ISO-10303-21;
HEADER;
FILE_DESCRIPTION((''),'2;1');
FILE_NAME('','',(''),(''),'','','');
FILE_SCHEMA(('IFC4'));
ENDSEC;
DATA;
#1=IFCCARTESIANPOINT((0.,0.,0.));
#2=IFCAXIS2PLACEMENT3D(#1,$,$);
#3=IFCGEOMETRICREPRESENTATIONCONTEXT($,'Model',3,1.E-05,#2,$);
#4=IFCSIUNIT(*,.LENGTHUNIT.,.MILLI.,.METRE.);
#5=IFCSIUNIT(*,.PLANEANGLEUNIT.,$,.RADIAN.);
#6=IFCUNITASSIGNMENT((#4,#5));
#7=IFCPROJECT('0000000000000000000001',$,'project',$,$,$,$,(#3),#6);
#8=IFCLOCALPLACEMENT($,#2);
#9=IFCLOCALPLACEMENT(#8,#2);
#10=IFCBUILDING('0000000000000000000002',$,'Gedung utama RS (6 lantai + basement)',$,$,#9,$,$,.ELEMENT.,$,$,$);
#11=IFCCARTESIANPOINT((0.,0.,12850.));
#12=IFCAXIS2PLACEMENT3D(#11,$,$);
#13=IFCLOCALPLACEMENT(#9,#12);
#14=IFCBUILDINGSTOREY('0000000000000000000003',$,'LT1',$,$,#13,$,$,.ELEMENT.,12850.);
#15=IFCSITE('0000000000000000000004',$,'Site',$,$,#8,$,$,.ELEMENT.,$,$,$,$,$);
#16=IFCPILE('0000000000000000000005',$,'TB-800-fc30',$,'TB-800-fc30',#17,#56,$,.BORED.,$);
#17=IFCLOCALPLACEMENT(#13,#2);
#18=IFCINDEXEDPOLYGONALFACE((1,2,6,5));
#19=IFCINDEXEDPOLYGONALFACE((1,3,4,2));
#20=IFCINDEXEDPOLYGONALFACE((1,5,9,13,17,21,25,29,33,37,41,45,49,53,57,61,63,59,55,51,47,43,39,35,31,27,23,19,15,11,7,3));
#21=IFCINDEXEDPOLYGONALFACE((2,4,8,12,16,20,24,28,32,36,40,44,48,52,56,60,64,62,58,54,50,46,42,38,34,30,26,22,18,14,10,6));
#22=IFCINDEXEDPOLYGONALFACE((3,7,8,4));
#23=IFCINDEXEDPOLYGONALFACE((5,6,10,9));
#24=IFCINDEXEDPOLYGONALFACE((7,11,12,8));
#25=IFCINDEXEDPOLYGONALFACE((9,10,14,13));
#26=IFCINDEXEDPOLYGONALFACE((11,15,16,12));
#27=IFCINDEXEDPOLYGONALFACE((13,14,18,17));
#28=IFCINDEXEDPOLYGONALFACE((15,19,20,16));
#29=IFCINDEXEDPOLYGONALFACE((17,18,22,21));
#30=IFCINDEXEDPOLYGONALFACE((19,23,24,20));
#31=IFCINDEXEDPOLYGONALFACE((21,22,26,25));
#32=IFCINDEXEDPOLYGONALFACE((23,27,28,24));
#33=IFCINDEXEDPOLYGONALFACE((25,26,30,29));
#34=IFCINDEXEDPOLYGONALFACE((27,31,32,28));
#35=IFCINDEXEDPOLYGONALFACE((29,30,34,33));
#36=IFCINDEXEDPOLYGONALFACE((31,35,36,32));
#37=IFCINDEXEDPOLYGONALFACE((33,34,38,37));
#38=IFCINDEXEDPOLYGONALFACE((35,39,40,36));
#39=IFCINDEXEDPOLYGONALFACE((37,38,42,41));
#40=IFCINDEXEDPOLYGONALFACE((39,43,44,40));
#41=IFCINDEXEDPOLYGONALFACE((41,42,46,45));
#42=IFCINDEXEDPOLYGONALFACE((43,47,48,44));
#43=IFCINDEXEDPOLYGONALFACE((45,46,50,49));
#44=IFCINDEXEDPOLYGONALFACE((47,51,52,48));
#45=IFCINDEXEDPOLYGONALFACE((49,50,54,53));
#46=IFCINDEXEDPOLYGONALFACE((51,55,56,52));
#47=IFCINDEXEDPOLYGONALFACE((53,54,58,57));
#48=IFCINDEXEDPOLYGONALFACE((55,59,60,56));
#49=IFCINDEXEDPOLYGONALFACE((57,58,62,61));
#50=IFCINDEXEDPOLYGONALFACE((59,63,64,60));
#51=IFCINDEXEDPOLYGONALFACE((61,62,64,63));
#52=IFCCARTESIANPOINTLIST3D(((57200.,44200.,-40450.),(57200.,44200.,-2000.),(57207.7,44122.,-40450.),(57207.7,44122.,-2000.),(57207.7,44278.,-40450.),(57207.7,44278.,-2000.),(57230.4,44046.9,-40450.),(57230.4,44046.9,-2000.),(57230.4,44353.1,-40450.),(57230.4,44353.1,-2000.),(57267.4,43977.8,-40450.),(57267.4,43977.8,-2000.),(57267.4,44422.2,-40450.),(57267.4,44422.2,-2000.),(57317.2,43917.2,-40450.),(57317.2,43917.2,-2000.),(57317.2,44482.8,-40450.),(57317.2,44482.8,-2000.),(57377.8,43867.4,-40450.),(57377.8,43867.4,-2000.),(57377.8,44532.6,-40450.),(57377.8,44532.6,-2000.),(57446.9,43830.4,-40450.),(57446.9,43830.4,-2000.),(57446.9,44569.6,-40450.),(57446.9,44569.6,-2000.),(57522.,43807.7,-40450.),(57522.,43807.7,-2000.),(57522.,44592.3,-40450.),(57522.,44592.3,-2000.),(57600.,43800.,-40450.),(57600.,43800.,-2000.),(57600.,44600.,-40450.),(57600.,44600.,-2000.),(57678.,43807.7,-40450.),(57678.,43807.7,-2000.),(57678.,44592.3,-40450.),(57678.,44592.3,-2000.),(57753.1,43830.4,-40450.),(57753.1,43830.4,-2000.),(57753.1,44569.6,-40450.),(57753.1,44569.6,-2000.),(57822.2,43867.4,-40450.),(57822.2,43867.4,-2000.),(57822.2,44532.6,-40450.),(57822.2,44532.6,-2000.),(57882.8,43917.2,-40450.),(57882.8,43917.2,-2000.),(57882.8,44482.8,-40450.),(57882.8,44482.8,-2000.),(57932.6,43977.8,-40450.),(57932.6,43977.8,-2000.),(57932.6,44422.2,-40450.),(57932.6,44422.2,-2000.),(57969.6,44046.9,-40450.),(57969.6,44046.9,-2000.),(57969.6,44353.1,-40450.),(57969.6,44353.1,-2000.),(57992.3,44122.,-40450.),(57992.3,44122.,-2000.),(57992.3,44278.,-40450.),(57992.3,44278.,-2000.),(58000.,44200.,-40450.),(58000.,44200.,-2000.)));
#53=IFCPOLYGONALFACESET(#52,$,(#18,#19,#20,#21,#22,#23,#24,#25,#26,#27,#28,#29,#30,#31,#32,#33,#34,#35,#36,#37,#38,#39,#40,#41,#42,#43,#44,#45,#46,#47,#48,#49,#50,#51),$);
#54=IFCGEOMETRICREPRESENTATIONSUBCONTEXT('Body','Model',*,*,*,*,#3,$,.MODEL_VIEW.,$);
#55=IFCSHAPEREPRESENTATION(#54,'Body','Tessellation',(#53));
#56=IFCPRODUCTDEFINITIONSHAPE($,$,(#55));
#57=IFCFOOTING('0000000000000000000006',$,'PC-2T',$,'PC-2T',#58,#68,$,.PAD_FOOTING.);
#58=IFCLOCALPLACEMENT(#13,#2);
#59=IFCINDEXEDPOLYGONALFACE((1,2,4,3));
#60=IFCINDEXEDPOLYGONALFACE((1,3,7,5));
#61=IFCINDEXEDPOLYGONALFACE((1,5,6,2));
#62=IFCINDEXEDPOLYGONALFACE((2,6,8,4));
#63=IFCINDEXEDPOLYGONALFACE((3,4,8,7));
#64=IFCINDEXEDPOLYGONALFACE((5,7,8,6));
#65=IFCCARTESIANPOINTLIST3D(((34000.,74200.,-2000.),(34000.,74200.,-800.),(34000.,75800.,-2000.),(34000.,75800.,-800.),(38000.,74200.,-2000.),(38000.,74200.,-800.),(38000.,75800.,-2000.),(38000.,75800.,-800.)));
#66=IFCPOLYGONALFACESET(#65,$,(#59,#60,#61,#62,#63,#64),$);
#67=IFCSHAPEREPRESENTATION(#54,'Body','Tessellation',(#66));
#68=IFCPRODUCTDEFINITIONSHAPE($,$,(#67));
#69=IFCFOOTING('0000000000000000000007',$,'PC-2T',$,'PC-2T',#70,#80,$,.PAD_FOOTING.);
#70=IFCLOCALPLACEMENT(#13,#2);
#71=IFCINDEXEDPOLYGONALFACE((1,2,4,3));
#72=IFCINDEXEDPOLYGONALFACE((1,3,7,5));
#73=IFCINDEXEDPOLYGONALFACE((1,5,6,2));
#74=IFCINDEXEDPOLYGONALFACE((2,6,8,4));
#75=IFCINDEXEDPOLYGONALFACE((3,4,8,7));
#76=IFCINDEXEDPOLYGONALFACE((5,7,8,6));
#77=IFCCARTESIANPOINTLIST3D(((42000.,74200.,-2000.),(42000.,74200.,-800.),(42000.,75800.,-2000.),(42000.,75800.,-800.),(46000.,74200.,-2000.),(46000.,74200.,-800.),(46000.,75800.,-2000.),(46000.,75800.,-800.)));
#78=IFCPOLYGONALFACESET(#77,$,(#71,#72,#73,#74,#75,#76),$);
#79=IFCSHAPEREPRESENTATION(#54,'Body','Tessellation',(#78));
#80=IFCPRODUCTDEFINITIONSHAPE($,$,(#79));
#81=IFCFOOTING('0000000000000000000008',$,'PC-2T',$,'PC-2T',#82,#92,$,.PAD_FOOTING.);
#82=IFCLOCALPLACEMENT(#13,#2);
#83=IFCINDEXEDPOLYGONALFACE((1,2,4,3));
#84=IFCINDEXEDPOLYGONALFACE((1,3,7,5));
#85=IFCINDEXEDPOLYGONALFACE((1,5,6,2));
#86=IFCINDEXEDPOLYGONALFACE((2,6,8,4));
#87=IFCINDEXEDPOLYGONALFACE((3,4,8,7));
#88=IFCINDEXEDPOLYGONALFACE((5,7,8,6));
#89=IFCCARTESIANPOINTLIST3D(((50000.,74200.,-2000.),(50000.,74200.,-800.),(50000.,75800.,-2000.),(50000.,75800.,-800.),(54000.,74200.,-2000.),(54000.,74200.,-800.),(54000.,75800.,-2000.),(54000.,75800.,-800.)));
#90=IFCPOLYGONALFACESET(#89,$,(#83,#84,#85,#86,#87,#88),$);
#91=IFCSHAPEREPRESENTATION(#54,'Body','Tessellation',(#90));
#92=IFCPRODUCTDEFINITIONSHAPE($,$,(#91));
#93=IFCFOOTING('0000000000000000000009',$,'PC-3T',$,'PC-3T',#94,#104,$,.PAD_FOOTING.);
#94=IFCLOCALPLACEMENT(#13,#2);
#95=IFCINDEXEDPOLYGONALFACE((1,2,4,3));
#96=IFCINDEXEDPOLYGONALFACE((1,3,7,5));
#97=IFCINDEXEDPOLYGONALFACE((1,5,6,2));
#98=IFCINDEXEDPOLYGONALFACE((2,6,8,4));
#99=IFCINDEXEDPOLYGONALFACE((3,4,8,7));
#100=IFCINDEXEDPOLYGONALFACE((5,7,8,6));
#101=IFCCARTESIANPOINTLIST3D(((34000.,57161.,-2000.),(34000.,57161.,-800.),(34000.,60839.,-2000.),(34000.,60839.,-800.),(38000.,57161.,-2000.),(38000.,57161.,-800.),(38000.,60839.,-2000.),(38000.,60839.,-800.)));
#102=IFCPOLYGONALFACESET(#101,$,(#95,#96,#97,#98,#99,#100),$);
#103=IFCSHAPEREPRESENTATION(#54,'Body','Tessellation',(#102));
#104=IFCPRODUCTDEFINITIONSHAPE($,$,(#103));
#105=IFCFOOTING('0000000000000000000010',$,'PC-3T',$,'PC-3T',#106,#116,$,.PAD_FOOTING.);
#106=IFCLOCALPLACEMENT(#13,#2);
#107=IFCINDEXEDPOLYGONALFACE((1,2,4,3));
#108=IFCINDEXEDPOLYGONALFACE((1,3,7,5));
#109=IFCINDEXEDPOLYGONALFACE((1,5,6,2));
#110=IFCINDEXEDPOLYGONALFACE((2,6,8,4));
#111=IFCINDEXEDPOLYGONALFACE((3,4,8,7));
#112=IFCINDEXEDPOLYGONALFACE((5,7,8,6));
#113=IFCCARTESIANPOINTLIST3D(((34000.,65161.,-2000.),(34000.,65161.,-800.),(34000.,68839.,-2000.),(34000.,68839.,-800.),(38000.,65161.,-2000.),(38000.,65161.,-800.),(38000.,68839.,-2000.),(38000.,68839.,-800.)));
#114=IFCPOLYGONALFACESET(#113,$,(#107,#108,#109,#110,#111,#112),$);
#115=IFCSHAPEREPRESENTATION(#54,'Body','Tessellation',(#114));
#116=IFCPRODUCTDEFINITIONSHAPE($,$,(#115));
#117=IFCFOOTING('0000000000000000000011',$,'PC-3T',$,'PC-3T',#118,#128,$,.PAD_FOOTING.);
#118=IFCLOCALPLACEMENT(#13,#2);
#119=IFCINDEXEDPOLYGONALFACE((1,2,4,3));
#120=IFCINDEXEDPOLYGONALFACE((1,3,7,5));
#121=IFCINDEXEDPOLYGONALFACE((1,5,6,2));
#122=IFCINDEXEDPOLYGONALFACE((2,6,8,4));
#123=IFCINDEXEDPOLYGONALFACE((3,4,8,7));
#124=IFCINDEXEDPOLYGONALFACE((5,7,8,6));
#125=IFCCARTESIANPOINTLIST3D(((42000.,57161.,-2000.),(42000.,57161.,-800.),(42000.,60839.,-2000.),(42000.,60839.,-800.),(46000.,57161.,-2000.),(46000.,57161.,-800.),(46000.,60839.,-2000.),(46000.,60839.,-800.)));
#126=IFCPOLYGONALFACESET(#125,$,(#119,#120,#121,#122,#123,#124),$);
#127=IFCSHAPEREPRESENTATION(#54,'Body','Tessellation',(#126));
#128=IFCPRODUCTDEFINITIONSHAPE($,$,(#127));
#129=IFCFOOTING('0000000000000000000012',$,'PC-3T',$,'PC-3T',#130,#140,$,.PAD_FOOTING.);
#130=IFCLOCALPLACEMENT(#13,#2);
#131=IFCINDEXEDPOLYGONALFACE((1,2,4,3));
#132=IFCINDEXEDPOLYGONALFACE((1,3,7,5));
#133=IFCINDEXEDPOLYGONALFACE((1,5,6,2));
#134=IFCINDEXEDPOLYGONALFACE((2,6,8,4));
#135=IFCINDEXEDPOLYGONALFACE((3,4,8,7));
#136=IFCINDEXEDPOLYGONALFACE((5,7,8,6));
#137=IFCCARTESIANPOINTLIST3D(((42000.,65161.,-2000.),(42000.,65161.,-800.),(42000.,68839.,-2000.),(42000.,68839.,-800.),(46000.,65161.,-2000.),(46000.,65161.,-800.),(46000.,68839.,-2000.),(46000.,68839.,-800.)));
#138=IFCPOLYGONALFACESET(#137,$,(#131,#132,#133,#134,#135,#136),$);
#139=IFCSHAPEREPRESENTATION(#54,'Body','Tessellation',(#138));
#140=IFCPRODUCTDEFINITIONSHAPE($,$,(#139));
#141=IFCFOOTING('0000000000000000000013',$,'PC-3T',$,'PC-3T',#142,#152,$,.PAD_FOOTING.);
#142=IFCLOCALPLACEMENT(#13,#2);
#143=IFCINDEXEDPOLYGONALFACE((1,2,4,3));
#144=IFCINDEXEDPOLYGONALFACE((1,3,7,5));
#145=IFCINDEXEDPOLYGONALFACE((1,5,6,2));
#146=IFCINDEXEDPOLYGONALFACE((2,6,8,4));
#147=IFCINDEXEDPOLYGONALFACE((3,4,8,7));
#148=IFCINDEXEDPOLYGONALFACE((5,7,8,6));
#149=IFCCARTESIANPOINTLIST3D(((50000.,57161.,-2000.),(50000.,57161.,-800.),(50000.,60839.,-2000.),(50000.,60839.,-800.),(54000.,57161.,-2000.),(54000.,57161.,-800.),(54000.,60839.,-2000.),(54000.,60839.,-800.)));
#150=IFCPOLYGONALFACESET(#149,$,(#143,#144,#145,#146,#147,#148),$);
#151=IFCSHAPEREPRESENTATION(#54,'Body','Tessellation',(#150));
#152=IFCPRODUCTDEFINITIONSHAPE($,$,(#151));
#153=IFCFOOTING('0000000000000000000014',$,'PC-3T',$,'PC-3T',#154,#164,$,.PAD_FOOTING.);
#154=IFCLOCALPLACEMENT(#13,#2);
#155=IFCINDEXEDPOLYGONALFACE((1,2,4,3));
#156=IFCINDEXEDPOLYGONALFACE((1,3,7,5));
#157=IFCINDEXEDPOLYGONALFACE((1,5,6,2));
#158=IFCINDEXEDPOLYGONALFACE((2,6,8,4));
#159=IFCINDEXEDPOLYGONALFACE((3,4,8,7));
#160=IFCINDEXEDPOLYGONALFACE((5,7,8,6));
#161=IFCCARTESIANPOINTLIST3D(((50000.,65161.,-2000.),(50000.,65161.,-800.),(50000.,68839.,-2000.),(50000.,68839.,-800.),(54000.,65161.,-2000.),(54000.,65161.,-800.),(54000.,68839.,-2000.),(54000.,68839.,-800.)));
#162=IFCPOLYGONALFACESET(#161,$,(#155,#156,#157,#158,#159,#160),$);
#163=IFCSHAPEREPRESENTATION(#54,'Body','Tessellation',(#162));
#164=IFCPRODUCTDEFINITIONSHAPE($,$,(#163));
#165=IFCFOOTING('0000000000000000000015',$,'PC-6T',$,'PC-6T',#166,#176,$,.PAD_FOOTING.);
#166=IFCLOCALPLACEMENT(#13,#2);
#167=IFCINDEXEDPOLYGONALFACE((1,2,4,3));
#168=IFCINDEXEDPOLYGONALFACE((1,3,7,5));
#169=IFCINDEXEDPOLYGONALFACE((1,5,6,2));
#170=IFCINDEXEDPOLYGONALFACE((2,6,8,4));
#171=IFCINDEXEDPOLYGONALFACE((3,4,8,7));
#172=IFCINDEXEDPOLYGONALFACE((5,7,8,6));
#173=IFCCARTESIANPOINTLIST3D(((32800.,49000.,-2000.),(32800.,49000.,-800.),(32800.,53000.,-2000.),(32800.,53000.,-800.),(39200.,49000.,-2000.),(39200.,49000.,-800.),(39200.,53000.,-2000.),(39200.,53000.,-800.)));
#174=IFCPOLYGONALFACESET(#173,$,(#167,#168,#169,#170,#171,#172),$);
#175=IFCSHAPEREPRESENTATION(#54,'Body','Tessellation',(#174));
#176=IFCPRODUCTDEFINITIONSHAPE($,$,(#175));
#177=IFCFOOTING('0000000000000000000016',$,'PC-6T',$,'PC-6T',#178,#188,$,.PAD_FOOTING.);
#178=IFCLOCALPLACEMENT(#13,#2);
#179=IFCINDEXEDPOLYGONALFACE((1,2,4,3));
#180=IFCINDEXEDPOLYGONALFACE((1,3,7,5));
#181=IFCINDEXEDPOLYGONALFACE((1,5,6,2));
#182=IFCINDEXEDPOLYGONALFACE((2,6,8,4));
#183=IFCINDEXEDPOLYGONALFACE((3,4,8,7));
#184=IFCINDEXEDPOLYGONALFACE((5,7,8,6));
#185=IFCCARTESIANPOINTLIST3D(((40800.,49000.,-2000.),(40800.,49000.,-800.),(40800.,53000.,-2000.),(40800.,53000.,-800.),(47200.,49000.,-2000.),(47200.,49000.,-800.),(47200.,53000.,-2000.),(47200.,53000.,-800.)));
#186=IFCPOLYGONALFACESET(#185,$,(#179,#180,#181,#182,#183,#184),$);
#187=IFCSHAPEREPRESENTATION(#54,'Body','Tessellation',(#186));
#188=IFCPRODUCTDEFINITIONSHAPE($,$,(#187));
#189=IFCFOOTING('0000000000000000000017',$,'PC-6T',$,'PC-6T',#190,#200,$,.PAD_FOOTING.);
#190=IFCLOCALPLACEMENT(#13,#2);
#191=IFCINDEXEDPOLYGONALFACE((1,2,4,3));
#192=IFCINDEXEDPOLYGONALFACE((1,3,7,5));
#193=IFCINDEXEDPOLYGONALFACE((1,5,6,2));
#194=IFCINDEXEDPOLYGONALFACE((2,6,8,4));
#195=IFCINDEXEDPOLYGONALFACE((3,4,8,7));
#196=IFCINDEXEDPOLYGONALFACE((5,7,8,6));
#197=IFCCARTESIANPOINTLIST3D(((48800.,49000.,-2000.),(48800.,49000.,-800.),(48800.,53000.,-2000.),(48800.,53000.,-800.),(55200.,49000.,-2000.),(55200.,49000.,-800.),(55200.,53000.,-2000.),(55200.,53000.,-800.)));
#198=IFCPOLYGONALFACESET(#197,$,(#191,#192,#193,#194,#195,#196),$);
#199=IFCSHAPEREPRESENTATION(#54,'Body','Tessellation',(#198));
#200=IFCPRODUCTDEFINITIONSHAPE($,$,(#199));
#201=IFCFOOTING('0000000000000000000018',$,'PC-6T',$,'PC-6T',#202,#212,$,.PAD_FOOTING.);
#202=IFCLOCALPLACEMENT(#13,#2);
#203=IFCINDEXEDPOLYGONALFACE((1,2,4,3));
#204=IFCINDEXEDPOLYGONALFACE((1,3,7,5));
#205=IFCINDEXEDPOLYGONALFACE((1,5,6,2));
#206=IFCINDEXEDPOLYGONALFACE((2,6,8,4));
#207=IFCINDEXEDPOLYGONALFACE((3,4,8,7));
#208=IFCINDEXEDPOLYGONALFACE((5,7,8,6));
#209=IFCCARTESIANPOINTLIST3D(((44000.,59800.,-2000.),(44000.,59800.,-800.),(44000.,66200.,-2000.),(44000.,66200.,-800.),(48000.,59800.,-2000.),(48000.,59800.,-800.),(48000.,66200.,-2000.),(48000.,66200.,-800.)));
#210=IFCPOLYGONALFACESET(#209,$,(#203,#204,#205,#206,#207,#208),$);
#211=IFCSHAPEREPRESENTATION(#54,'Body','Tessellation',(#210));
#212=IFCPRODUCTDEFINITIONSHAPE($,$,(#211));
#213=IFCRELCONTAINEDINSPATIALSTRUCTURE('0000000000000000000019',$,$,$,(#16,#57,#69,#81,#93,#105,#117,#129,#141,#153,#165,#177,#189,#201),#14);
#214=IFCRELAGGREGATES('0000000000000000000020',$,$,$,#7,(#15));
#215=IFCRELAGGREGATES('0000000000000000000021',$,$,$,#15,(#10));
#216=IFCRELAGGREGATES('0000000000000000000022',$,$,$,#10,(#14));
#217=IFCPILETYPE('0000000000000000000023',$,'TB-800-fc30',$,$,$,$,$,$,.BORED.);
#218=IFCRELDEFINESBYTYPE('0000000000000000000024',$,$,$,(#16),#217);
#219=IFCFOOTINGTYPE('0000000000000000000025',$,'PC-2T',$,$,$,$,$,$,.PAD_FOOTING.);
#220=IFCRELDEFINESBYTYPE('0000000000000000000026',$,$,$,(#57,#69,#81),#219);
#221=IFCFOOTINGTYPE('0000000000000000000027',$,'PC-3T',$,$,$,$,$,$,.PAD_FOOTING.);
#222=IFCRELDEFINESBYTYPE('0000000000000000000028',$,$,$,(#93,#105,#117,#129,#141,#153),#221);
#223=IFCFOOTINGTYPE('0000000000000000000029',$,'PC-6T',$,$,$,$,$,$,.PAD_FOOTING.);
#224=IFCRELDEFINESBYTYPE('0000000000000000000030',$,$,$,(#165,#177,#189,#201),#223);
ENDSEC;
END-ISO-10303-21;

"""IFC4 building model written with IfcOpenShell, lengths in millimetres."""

from ifc_helpers import new_model, si_unit, frame, origin, origin_2d, place, context, subcontext, project, spatial, rectangle, circle, extrude, material_profile, profile_set, profile_usage, type_object, element, save


model = new_model("IFC4")

# Units and contexts
model_context = context("Model", 3, precision=1e-05, world=origin())
body_context = subcontext(model_context, "Body", "Model", "MODEL_VIEW")
ifc_project = project(units=[si_unit("LENGTHUNIT", "METRE", prefix="MILLI"), si_unit("PLANEANGLEUNIT", "RADIAN")], contexts=[model_context])

# Site, building, storey
site_placement = place(None, origin())
site = spatial("IfcSite", under=ifc_project, at=site_placement, Name="Site", CompositionType="ELEMENT")
building_placement = place(site_placement, origin())
building = spatial("IfcBuilding", under=site, at=building_placement, Name="Gedung utama RS (6 lantai + basement)", CompositionType="ELEMENT")
storey_placement = place(building_placement, frame((0.0, 0.0, 12850.0)))
storey = spatial("IfcBuildingStorey", under=building, at=storey_placement, Name="LT1", CompositionType="ELEMENT", Elevation=12850.0)

# Pile
ifc_material_profile_1 = material_profile(None, circle(Radius=400.0, at=origin_2d()), Name="TB-800-fc30")
ifc_profile_set_1 = profile_set([ifc_material_profile_1], Name="TB-800-fc30")
ifc_profile_usage_1 = profile_usage(ifc_profile_set_1, cardinal=5)
pile_type = type_object("IfcPileType", Name="TB-800-fc30", PredefinedType="BORED", material=ifc_profile_set_1)
for number, where, z_axis, x_axis, name in (
    (1, (57600.0, 44200.0, -40450.0), (0.0, 0.0, 1.0), (1.0, 0.0, 0.0), "TB-800-fc30"),
):
    element("IfcPile", number, at=place(storey_placement, frame(where, z_axis=z_axis, x_axis=x_axis)), inside=storey, type_object=pile_type, material=ifc_profile_usage_1, Name=name, ObjectType="TB-800-fc30", PredefinedType="BORED", context=body_context, shape_type="SweptSolid", body=[
        extrude(circle(Radius=400.0, at=origin_2d()), origin(), (0.0, 0.0, 1.0), 38450.0),
    ])

# Footings
ifc_material_profile_2 = material_profile(None, rectangle(XDim=4000.0, YDim=1600.0, at=origin_2d()), Name="PC-2T")
ifc_profile_set_2 = profile_set([ifc_material_profile_2], Name="PC-2T")
ifc_profile_usage_2 = profile_usage(ifc_profile_set_2, cardinal=5)
footing_type_1 = type_object("IfcFootingType", Name="PC-2T", PredefinedType="PAD_FOOTING", material=ifc_profile_set_2)
for number, where, z_axis, x_axis, name in (
    (2, (36000.0, 75000.0, -2000.0), (0.0, 0.0, 1.0), (1.0, 0.0, 0.0), "PC-2T"),
    (3, (44000.0, 75000.0, -2000.0), (0.0, 0.0, 1.0), (1.0, 0.0, 0.0), "PC-2T"),
    (4, (52000.0, 75000.0, -2000.0), (0.0, 0.0, 1.0), (1.0, 0.0, 0.0), "PC-2T"),
):
    element("IfcFooting", number, at=place(storey_placement, frame(where, z_axis=z_axis, x_axis=x_axis)), inside=storey, type_object=footing_type_1, material=ifc_profile_usage_2, Name=name, ObjectType="PC-2T", PredefinedType="PAD_FOOTING", context=body_context, shape_type="SweptSolid", body=[
        extrude(rectangle(XDim=4000.0, YDim=1600.0, at=origin_2d()), origin(), (0.0, 0.0, 1.0), 1200.0),
    ])
ifc_material_profile_3 = material_profile(None, rectangle(XDim=4000.0, YDim=3678.0, at=origin_2d()), Name="PC-3T")
ifc_profile_set_3 = profile_set([ifc_material_profile_3], Name="PC-3T")
ifc_profile_usage_3 = profile_usage(ifc_profile_set_3, cardinal=5)
footing_type_2 = type_object("IfcFootingType", Name="PC-3T", PredefinedType="PAD_FOOTING", material=ifc_profile_set_3)
for number, where, z_axis, x_axis, name in (
    (5, (36000.0, 59000.0, -2000.0), (0.0, 0.0, 1.0), (1.0, 0.0, 0.0), "PC-3T"),
    (6, (36000.0, 67000.0, -2000.0), (0.0, 0.0, 1.0), (1.0, 0.0, 0.0), "PC-3T"),
    (7, (44000.0, 59000.0, -2000.0), (0.0, 0.0, 1.0), (1.0, 0.0, 0.0), "PC-3T"),
    (8, (44000.0, 67000.0, -2000.0), (0.0, 0.0, 1.0), (1.0, 0.0, 0.0), "PC-3T"),
    (9, (52000.0, 59000.0, -2000.0), (0.0, 0.0, 1.0), (1.0, 0.0, 0.0), "PC-3T"),
    (10, (52000.0, 67000.0, -2000.0), (0.0, 0.0, 1.0), (1.0, 0.0, 0.0), "PC-3T"),
):
    element("IfcFooting", number, at=place(storey_placement, frame(where, z_axis=z_axis, x_axis=x_axis)), inside=storey, type_object=footing_type_2, material=ifc_profile_usage_3, Name=name, ObjectType="PC-3T", PredefinedType="PAD_FOOTING", context=body_context, shape_type="SweptSolid", body=[
        extrude(rectangle(XDim=4000.0, YDim=3678.0, at=origin_2d()), origin(), (0.0, 0.0, 1.0), 1200.0),
    ])
ifc_material_profile_4 = material_profile(None, rectangle(XDim=6400.0, YDim=4000.0, at=origin_2d()), Name="PC-6T")
ifc_profile_set_4 = profile_set([ifc_material_profile_4], Name="PC-6T")
ifc_profile_usage_4 = profile_usage(ifc_profile_set_4, cardinal=5)
footing_type_3 = type_object("IfcFootingType", Name="PC-6T", PredefinedType="PAD_FOOTING", material=ifc_profile_set_4)
for number, where, z_axis, x_axis, name in (
    (11, (36000.0, 51000.0, -2000.0), (0.0, 0.0, 1.0), (1.0, 0.0, 0.0), "PC-6T"),
    (12, (44000.0, 51000.0, -2000.0), (0.0, 0.0, 1.0), (1.0, 0.0, 0.0), "PC-6T"),
    (13, (52000.0, 51000.0, -2000.0), (0.0, 0.0, 1.0), (1.0, 0.0, 0.0), "PC-6T"),
    (14, (46000.0, 63000.0, -2000.0), (0.0, 0.0, 1.0), (0.0, 1.0, 0.0), "PC-6T"),
):
    element("IfcFooting", number, at=place(storey_placement, frame(where, z_axis=z_axis, x_axis=x_axis)), inside=storey, type_object=footing_type_3, material=ifc_profile_usage_4, Name=name, ObjectType="PC-6T", PredefinedType="PAD_FOOTING", context=body_context, shape_type="SweptSolid", body=[
        extrude(rectangle(XDim=6400.0, YDim=4000.0, at=origin_2d()), origin(), (0.0, 0.0, 1.0), 1200.0),
    ])

save(model, "model.ifc")
